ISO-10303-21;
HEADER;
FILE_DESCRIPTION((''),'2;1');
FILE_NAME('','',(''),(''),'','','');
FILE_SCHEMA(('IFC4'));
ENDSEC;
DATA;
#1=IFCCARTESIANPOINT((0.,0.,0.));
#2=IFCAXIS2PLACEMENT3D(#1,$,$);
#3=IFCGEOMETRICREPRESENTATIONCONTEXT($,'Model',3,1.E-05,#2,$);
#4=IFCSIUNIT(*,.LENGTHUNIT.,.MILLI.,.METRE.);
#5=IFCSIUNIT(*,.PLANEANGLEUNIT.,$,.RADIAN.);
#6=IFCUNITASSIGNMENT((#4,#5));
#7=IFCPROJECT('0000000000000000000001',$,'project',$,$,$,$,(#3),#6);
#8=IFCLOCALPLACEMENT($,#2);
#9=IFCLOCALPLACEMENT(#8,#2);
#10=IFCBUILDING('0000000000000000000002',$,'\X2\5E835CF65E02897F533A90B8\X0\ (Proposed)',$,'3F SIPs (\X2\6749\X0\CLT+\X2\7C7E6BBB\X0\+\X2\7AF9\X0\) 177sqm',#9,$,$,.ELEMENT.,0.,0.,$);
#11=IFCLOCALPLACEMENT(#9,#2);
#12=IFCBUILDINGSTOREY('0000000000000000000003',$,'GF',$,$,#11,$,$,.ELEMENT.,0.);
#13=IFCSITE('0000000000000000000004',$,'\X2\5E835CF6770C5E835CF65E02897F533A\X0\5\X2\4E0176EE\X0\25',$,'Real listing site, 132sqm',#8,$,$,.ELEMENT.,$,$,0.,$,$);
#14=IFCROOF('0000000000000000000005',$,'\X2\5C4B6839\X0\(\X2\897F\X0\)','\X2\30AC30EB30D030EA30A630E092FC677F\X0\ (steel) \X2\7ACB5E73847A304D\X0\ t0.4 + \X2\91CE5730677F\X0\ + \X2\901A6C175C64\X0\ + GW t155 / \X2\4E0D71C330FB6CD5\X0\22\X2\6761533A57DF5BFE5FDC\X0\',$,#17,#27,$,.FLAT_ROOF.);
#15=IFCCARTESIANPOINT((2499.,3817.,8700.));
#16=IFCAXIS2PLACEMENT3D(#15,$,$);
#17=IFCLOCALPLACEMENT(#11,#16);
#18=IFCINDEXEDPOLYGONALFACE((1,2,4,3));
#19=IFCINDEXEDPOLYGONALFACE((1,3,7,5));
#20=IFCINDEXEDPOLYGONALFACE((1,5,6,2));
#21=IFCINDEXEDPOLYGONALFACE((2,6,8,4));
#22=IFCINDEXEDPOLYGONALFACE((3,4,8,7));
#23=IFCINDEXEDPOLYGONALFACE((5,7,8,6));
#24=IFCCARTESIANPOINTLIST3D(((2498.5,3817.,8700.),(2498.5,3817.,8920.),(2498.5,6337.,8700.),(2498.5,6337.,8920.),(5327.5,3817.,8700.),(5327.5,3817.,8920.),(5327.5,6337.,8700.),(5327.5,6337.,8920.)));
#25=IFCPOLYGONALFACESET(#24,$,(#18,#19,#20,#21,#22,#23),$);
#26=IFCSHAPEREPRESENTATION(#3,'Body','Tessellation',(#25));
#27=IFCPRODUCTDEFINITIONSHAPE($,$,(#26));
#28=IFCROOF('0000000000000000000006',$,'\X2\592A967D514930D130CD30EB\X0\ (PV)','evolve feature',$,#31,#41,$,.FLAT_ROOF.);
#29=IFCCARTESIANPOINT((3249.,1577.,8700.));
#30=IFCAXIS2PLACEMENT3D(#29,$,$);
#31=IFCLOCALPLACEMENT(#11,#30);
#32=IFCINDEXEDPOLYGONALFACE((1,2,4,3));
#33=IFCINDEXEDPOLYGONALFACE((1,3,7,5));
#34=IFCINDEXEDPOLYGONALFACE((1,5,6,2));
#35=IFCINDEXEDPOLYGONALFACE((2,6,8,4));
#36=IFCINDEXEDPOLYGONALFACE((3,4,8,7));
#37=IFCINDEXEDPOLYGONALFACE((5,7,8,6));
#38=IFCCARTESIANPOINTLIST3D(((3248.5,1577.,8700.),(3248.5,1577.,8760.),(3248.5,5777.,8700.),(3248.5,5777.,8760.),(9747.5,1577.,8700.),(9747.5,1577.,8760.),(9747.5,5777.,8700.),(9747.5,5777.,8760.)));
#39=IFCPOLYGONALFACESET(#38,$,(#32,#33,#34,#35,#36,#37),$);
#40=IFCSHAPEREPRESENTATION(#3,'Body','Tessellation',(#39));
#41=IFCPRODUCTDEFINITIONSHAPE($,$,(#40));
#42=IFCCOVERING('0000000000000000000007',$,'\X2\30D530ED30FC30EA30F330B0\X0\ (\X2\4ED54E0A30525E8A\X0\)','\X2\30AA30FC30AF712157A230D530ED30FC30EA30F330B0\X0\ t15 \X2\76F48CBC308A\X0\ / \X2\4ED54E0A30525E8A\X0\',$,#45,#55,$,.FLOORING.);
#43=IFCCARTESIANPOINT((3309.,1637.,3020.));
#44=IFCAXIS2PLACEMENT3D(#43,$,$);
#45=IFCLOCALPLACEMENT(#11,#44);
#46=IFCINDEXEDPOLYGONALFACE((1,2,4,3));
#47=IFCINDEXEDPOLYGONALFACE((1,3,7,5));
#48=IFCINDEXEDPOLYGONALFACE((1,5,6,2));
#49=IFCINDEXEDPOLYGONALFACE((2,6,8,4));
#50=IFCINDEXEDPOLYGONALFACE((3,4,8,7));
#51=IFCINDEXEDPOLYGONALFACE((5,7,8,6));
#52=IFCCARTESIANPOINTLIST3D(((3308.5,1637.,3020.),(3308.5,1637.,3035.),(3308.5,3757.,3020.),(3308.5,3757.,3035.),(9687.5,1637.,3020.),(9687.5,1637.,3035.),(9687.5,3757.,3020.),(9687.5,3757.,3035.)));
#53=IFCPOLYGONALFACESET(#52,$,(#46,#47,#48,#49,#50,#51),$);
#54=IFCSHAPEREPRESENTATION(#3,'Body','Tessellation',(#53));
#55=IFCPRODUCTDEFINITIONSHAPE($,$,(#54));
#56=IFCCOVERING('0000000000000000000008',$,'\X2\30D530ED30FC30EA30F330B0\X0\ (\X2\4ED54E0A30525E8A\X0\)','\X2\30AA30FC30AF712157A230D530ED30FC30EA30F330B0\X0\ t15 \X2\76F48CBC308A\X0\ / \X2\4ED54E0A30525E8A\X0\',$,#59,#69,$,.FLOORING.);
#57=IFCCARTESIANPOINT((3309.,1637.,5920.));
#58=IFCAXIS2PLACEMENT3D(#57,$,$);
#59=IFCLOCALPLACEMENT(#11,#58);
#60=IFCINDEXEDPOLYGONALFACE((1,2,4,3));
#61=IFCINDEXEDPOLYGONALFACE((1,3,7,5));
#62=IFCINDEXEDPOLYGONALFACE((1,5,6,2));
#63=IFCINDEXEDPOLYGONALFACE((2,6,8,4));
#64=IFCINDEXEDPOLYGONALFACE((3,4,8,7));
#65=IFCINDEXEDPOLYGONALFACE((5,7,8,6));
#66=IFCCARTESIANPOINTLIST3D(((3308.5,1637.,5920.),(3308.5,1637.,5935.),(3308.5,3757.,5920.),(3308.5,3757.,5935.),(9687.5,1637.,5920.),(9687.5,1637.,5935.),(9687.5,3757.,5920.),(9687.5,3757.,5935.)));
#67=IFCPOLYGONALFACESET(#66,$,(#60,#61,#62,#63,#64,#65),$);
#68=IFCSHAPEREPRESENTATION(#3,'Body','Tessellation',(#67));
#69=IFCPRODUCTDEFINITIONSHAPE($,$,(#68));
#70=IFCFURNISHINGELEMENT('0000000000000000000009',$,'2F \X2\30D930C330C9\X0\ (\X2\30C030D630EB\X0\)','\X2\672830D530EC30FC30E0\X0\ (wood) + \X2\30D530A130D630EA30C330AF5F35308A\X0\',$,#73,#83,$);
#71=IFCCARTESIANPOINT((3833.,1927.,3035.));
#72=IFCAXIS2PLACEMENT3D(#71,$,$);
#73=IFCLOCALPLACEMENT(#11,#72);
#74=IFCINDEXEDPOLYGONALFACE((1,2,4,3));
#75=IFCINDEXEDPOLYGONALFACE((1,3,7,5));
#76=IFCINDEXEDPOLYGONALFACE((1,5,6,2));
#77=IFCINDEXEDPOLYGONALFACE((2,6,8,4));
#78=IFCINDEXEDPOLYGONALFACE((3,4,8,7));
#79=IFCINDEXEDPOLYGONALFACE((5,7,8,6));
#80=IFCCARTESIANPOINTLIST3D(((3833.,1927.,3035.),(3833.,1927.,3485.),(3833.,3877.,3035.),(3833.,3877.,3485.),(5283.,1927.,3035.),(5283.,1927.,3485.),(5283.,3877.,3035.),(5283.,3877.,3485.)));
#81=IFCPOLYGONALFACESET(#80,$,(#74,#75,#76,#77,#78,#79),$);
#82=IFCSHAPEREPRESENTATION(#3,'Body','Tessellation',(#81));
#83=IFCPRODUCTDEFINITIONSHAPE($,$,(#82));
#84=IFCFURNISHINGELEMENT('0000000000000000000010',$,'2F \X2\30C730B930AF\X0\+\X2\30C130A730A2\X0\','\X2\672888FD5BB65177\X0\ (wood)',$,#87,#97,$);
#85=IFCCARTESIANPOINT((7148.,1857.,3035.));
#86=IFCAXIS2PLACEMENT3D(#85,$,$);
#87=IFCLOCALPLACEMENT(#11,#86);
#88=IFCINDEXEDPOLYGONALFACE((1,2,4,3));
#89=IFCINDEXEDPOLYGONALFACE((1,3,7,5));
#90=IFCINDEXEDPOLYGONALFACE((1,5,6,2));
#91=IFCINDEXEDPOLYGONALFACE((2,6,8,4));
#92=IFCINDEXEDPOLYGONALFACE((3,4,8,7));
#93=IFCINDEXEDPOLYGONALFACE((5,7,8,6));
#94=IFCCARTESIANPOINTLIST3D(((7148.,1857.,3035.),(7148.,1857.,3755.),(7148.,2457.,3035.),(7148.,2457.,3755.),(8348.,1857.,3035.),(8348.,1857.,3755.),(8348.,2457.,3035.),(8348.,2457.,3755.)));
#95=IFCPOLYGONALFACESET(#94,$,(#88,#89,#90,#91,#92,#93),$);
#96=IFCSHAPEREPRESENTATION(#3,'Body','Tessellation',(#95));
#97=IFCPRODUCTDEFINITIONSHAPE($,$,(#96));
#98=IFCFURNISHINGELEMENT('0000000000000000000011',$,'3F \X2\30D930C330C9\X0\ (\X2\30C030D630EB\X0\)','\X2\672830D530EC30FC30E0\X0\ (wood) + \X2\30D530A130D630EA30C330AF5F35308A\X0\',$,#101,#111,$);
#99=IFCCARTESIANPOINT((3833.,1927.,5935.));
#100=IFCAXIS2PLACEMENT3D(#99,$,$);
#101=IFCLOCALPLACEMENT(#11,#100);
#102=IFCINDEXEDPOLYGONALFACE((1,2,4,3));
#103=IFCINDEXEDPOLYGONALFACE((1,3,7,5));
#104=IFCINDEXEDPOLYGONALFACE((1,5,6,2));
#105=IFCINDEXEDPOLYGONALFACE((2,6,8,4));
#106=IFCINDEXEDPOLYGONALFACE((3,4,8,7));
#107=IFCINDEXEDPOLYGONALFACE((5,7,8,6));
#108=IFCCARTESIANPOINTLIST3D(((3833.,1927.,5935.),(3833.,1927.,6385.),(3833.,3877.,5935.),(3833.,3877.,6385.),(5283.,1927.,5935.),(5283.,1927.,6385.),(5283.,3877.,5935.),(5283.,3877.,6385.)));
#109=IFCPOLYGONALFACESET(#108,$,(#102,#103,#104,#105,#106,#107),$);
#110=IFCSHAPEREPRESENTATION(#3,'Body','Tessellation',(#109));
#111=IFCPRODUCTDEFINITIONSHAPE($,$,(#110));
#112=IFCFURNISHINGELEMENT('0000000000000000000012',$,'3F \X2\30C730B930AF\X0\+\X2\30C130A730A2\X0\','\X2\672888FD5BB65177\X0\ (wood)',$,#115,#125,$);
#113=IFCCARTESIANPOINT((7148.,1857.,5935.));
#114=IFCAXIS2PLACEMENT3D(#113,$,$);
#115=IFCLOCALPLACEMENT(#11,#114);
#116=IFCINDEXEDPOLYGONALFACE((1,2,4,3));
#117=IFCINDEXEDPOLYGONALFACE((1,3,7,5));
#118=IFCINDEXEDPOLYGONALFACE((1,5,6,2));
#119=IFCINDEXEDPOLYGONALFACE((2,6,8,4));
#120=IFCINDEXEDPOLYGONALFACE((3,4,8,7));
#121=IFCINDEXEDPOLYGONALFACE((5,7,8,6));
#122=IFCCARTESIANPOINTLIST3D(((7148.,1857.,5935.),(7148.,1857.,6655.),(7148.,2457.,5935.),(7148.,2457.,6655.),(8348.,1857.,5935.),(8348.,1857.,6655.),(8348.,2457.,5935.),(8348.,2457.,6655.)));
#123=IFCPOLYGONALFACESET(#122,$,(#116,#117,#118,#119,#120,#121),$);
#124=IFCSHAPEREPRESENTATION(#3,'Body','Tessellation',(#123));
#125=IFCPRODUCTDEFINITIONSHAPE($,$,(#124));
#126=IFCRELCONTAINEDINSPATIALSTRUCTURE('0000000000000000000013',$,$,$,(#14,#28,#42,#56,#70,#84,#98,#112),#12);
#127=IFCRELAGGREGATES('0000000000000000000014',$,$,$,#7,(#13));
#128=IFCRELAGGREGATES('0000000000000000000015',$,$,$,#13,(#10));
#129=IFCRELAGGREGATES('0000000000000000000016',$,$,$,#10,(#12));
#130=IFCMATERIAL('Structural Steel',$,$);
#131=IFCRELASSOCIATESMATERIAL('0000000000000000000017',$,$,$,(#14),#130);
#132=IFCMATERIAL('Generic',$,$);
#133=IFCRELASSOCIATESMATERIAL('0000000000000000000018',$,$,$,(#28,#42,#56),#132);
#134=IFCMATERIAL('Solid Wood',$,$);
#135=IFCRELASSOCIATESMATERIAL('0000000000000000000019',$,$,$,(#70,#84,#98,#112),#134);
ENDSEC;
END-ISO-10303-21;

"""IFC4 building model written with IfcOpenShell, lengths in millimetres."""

from ifc_helpers import new_model, si_unit, frame, frame_2d, origin, place, context, project, spatial, rectangle, extrude, material, element, save


model = new_model("IFC4")

# Units and contexts
model_context = context("Model", 3, precision=1e-05, world=origin())
ifc_project = project(units=[si_unit("LENGTHUNIT", "METRE", prefix="MILLI"), si_unit("PLANEANGLEUNIT", "RADIAN")], contexts=[model_context])

# Site, building, storey
site_placement = place(None, origin())
site = spatial("IfcSite", under=ifc_project, at=site_placement, Name="広島県広島市西区5丁目25", ObjectType="Real listing site, 132sqm", CompositionType="ELEMENT", RefElevation=0.0)
building_placement = place(site_placement, origin())
building = spatial("IfcBuilding", under=site, at=building_placement, Name="広島市西区邸 (Proposed)", ObjectType="3F SIPs (杉CLT+籾殻+竹) 177sqm", CompositionType="ELEMENT", ElevationOfRefHeight=0.0, ElevationOfTerrain=0.0)
storey_placement = place(building_placement, origin())
storey = spatial("IfcBuildingStorey", under=building, at=storey_placement, Name="GF", CompositionType="ELEMENT", Elevation=0.0)

# Shared definitions
ifc_material_1 = material(Name="Solid Wood")

# Roofs
ifc_material_2 = material(Name="Structural Steel")
roof_1_placement = place(storey_placement, frame((2499.0, 3817.0, 8700.0)))
element("IfcRoof", 1, at=roof_1_placement, inside=storey, material=ifc_material_2, Name="屋根(西)", Description="ガルバリウム鋼板 (steel) 立平葺き t0.4 + 野地板 + 通気層 + GW t155 / 不燃・法22条区域対応", PredefinedType="FLAT_ROOF", context=model_context, shape_type="SweptSolid", body=[
    extrude(rectangle(XDim=2829.0, YDim=2520.0, at=frame_2d((1414.0, 1260.0))), frame((2499.0, 3817.0, 8700.0)), (0.0, 0.0, 1.0), 220.0),
])
ifc_material_3 = material(Name="Generic")
roof_2_placement = place(storey_placement, frame((3249.0, 1577.0, 8700.0)))
element("IfcRoof", 2, at=roof_2_placement, inside=storey, material=ifc_material_3, Name="太陽光パネル (PV)", Description="evolve feature", PredefinedType="FLAT_ROOF", context=model_context, shape_type="SweptSolid", body=[
    extrude(rectangle(XDim=6499.0, YDim=4200.0, at=frame_2d((3249.0, 2100.0))), frame((3249.0, 1577.0, 8700.0)), (0.0, 0.0, 1.0), 60.0),
])

# Coverings
covering_1_placement = place(storey_placement, frame((3309.0, 1637.0, 3020.0)))
element("IfcCovering", 3, at=covering_1_placement, inside=storey, material=ifc_material_3, Name="フローリング (仕上げ床)", Description="オーク無垢フローリング t15 直貼り / 仕上げ床", PredefinedType="FLOORING", context=model_context, shape_type="SweptSolid", body=[
    extrude(rectangle(XDim=6379.0, YDim=2120.0, at=frame_2d((3189.0, 1060.0))), frame((3309.0, 1637.0, 3020.0)), (0.0, 0.0, 1.0), 15.0),
])
covering_2_placement = place(storey_placement, frame((3309.0, 1637.0, 5920.0)))
element("IfcCovering", 4, at=covering_2_placement, inside=storey, material=ifc_material_3, Name="フローリング (仕上げ床)", Description="オーク無垢フローリング t15 直貼り / 仕上げ床", PredefinedType="FLOORING", context=model_context, shape_type="SweptSolid", body=[
    extrude(rectangle(XDim=6379.0, YDim=2120.0, at=frame_2d((3189.0, 1060.0))), frame((3309.0, 1637.0, 5920.0)), (0.0, 0.0, 1.0), 15.0),
])

# Furnishing elements
furnishing_1_placement = place(storey_placement, frame((3833.0, 1927.0, 3035.0)))
element("IfcFurnishingElement", 5, at=furnishing_1_placement, inside=storey, material=ifc_material_1, Name="2F ベッド (ダブル)", Description="木フレーム (wood) + ファブリック張り", context=model_context, shape_type="SweptSolid", body=[
    extrude(rectangle(XDim=1450.0, YDim=1950.0, at=frame_2d((725.0, 975.0))), frame((3833.0, 1927.0, 3035.0)), (0.0, 0.0, 1.0), 450.0),
])
furnishing_2_placement = place(storey_placement, frame((7148.0, 1857.0, 3035.0)))
element("IfcFurnishingElement", 6, at=furnishing_2_placement, inside=storey, material=ifc_material_1, Name="2F デスク+チェア", Description="木製家具 (wood)", context=model_context, shape_type="SweptSolid", body=[
    extrude(rectangle(XDim=1200.0, YDim=600.0, at=frame_2d((600.0, 300.0))), frame((7148.0, 1857.0, 3035.0)), (0.0, 0.0, 1.0), 720.0),
])
furnishing_3_placement = place(storey_placement, frame((3833.0, 1927.0, 5935.0)))
element("IfcFurnishingElement", 7, at=furnishing_3_placement, inside=storey, material=ifc_material_1, Name="3F ベッド (ダブル)", Description="木フレーム (wood) + ファブリック張り", context=model_context, shape_type="SweptSolid", body=[
    extrude(rectangle(XDim=1450.0, YDim=1950.0, at=frame_2d((725.0, 975.0))), frame((3833.0, 1927.0, 5935.0)), (0.0, 0.0, 1.0), 450.0),
])
furnishing_4_placement = place(storey_placement, frame((7148.0, 1857.0, 5935.0)))
element("IfcFurnishingElement", 8, at=furnishing_4_placement, inside=storey, material=ifc_material_1, Name="3F デスク+チェア", Description="木製家具 (wood)", context=model_context, shape_type="SweptSolid", body=[
    extrude(rectangle(XDim=1200.0, YDim=600.0, at=frame_2d((600.0, 300.0))), frame((7148.0, 1857.0, 5935.0)), (0.0, 0.0, 1.0), 720.0),
])

save(model, "model.ifc")
